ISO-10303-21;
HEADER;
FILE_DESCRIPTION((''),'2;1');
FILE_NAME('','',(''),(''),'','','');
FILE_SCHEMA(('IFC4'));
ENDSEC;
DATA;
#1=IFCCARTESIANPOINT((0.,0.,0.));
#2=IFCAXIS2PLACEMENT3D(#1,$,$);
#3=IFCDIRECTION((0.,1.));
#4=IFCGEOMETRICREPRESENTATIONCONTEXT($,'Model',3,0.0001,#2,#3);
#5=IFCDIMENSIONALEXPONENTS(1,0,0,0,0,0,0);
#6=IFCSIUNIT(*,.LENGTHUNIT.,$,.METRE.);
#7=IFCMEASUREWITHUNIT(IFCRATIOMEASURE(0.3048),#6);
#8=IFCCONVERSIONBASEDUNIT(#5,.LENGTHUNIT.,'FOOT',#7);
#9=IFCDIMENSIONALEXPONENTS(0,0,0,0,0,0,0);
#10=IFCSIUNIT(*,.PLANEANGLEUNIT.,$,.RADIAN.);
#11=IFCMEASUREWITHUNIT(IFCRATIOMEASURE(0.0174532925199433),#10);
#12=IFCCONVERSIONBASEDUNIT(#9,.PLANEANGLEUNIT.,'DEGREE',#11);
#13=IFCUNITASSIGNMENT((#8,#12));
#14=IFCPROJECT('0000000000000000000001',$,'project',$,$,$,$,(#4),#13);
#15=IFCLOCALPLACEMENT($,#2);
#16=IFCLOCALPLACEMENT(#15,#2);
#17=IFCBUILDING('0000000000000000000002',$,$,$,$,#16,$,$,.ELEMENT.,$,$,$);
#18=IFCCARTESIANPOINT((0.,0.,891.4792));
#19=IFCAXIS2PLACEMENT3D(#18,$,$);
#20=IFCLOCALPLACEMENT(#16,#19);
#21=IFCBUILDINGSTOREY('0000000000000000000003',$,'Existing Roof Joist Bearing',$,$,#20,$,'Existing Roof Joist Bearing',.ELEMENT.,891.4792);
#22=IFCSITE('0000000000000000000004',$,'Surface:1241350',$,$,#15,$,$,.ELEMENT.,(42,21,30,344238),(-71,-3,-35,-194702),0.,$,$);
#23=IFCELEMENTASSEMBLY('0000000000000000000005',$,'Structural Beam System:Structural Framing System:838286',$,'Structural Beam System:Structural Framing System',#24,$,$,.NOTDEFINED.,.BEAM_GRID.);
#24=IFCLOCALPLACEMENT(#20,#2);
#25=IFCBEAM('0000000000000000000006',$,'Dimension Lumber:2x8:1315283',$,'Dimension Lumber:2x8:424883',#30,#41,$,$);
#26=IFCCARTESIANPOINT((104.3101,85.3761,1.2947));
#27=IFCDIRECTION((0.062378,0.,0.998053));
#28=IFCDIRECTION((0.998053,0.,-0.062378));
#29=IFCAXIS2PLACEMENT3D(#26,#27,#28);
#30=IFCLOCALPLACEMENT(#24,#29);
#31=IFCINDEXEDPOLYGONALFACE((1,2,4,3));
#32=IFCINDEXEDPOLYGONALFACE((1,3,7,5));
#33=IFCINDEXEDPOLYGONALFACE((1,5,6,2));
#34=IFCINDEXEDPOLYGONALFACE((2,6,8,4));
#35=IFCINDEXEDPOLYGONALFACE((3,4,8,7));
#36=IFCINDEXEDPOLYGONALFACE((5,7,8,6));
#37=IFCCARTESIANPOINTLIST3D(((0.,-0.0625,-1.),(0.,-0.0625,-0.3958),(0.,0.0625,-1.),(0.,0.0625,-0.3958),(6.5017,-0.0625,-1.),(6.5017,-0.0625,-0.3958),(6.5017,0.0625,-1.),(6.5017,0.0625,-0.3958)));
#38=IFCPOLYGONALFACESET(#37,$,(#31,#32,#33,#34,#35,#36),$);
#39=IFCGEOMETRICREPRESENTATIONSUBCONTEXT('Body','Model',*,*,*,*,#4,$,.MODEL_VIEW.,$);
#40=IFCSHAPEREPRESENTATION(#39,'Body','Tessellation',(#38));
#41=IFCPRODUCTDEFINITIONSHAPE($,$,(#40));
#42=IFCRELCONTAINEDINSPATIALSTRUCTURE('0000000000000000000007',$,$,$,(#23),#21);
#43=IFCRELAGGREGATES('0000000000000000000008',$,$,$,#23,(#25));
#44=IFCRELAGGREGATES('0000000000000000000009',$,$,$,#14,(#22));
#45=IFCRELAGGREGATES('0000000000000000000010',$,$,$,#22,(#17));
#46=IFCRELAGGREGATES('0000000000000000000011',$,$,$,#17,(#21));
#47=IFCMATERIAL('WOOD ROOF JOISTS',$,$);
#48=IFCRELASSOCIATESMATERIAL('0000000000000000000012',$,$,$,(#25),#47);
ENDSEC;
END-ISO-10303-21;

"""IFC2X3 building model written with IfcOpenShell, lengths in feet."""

from ifc_helpers import new_model, entity, si_unit, converted_unit, direction, frame, frame_2d, origin, place, context, subcontext, project, spatial, rectangle, extrude, material, element, aggregate, save


model = new_model("IFC2X3")

# Units and contexts
model_context = context("Model", 3, precision=0.0001, world=origin(), true_north=direction((0.0, 1.0)))
body_context = subcontext(model_context, "Body", "Model", "MODEL_VIEW")
ifc_project = project(units=[converted_unit("LENGTHUNIT", "FOOT", entity("IfcRatioMeasure", 0.3048), si_unit("LENGTHUNIT", "METRE"), dimensions=[1, 0, 0, 0, 0, 0, 0]), converted_unit("PLANEANGLEUNIT", "DEGREE", entity("IfcRatioMeasure", 0.0174532925199433), si_unit("PLANEANGLEUNIT", "RADIAN"), dimensions=[0, 0, 0, 0, 0, 0, 0])], contexts=[model_context])

# Site, building, storey
site_placement = place(None, origin())
site = spatial("IfcSite", under=ifc_project, at=site_placement, Name="Surface:1241350", CompositionType="ELEMENT", RefLatitude=(42, 21, 30, 344238), RefLongitude=(-71, -3, -35, -194702), RefElevation=0.0)
building_placement = place(site_placement, origin())
building = spatial("IfcBuilding", under=site, at=building_placement, CompositionType="ELEMENT")
storey_placement = place(building_placement, frame((0.0, 0.0, 891.4792)))
storey = spatial("IfcBuildingStorey", under=building, at=storey_placement, Name="Existing Roof Joist Bearing", LongName="Existing Roof Joist Bearing", CompositionType="ELEMENT", Elevation=891.4792)

# Element assembly, beam
assembly_1_placement = place(storey_placement, origin())
assembly_1 = element("IfcElementAssembly", 1, at=assembly_1_placement, inside=storey, Name="Structural Beam System:Structural Framing System:838286", ObjectType="Structural Beam System:Structural Framing System", AssemblyPlace="NOTDEFINED", PredefinedType="BEAM_GRID")
ifc_material_1 = material(Name="WOOD ROOF JOISTS")
beam_1_placement = place(assembly_1_placement, frame((104.3101, 85.3761, 1.2947), z_axis=(0.062378, 0.0, 0.998053), x_axis=(0.998053, 0.0, -0.062378)))
beam_1 = element("IfcBeam", 2, at=beam_1_placement, material=ifc_material_1, Name="Dimension Lumber:2x8:1315283", ObjectType="Dimension Lumber:2x8:424883", context=body_context, shape_type="SweptSolid", body=[
    extrude(rectangle(XDim=0.6042, YDim=0.125, at=frame_2d((0.0, 0.0), x_axis=(1.0, 0.0))), frame((0.0, 0.0, -0.6979), z_axis=(1.0, 0.0, 0.0), x_axis=(0.0, 0.0, -1.0)), (0.0, 0.0, 1.0), 6.5017),
])
aggregate(assembly_1, [beam_1])

save(model, "model.ifc")
